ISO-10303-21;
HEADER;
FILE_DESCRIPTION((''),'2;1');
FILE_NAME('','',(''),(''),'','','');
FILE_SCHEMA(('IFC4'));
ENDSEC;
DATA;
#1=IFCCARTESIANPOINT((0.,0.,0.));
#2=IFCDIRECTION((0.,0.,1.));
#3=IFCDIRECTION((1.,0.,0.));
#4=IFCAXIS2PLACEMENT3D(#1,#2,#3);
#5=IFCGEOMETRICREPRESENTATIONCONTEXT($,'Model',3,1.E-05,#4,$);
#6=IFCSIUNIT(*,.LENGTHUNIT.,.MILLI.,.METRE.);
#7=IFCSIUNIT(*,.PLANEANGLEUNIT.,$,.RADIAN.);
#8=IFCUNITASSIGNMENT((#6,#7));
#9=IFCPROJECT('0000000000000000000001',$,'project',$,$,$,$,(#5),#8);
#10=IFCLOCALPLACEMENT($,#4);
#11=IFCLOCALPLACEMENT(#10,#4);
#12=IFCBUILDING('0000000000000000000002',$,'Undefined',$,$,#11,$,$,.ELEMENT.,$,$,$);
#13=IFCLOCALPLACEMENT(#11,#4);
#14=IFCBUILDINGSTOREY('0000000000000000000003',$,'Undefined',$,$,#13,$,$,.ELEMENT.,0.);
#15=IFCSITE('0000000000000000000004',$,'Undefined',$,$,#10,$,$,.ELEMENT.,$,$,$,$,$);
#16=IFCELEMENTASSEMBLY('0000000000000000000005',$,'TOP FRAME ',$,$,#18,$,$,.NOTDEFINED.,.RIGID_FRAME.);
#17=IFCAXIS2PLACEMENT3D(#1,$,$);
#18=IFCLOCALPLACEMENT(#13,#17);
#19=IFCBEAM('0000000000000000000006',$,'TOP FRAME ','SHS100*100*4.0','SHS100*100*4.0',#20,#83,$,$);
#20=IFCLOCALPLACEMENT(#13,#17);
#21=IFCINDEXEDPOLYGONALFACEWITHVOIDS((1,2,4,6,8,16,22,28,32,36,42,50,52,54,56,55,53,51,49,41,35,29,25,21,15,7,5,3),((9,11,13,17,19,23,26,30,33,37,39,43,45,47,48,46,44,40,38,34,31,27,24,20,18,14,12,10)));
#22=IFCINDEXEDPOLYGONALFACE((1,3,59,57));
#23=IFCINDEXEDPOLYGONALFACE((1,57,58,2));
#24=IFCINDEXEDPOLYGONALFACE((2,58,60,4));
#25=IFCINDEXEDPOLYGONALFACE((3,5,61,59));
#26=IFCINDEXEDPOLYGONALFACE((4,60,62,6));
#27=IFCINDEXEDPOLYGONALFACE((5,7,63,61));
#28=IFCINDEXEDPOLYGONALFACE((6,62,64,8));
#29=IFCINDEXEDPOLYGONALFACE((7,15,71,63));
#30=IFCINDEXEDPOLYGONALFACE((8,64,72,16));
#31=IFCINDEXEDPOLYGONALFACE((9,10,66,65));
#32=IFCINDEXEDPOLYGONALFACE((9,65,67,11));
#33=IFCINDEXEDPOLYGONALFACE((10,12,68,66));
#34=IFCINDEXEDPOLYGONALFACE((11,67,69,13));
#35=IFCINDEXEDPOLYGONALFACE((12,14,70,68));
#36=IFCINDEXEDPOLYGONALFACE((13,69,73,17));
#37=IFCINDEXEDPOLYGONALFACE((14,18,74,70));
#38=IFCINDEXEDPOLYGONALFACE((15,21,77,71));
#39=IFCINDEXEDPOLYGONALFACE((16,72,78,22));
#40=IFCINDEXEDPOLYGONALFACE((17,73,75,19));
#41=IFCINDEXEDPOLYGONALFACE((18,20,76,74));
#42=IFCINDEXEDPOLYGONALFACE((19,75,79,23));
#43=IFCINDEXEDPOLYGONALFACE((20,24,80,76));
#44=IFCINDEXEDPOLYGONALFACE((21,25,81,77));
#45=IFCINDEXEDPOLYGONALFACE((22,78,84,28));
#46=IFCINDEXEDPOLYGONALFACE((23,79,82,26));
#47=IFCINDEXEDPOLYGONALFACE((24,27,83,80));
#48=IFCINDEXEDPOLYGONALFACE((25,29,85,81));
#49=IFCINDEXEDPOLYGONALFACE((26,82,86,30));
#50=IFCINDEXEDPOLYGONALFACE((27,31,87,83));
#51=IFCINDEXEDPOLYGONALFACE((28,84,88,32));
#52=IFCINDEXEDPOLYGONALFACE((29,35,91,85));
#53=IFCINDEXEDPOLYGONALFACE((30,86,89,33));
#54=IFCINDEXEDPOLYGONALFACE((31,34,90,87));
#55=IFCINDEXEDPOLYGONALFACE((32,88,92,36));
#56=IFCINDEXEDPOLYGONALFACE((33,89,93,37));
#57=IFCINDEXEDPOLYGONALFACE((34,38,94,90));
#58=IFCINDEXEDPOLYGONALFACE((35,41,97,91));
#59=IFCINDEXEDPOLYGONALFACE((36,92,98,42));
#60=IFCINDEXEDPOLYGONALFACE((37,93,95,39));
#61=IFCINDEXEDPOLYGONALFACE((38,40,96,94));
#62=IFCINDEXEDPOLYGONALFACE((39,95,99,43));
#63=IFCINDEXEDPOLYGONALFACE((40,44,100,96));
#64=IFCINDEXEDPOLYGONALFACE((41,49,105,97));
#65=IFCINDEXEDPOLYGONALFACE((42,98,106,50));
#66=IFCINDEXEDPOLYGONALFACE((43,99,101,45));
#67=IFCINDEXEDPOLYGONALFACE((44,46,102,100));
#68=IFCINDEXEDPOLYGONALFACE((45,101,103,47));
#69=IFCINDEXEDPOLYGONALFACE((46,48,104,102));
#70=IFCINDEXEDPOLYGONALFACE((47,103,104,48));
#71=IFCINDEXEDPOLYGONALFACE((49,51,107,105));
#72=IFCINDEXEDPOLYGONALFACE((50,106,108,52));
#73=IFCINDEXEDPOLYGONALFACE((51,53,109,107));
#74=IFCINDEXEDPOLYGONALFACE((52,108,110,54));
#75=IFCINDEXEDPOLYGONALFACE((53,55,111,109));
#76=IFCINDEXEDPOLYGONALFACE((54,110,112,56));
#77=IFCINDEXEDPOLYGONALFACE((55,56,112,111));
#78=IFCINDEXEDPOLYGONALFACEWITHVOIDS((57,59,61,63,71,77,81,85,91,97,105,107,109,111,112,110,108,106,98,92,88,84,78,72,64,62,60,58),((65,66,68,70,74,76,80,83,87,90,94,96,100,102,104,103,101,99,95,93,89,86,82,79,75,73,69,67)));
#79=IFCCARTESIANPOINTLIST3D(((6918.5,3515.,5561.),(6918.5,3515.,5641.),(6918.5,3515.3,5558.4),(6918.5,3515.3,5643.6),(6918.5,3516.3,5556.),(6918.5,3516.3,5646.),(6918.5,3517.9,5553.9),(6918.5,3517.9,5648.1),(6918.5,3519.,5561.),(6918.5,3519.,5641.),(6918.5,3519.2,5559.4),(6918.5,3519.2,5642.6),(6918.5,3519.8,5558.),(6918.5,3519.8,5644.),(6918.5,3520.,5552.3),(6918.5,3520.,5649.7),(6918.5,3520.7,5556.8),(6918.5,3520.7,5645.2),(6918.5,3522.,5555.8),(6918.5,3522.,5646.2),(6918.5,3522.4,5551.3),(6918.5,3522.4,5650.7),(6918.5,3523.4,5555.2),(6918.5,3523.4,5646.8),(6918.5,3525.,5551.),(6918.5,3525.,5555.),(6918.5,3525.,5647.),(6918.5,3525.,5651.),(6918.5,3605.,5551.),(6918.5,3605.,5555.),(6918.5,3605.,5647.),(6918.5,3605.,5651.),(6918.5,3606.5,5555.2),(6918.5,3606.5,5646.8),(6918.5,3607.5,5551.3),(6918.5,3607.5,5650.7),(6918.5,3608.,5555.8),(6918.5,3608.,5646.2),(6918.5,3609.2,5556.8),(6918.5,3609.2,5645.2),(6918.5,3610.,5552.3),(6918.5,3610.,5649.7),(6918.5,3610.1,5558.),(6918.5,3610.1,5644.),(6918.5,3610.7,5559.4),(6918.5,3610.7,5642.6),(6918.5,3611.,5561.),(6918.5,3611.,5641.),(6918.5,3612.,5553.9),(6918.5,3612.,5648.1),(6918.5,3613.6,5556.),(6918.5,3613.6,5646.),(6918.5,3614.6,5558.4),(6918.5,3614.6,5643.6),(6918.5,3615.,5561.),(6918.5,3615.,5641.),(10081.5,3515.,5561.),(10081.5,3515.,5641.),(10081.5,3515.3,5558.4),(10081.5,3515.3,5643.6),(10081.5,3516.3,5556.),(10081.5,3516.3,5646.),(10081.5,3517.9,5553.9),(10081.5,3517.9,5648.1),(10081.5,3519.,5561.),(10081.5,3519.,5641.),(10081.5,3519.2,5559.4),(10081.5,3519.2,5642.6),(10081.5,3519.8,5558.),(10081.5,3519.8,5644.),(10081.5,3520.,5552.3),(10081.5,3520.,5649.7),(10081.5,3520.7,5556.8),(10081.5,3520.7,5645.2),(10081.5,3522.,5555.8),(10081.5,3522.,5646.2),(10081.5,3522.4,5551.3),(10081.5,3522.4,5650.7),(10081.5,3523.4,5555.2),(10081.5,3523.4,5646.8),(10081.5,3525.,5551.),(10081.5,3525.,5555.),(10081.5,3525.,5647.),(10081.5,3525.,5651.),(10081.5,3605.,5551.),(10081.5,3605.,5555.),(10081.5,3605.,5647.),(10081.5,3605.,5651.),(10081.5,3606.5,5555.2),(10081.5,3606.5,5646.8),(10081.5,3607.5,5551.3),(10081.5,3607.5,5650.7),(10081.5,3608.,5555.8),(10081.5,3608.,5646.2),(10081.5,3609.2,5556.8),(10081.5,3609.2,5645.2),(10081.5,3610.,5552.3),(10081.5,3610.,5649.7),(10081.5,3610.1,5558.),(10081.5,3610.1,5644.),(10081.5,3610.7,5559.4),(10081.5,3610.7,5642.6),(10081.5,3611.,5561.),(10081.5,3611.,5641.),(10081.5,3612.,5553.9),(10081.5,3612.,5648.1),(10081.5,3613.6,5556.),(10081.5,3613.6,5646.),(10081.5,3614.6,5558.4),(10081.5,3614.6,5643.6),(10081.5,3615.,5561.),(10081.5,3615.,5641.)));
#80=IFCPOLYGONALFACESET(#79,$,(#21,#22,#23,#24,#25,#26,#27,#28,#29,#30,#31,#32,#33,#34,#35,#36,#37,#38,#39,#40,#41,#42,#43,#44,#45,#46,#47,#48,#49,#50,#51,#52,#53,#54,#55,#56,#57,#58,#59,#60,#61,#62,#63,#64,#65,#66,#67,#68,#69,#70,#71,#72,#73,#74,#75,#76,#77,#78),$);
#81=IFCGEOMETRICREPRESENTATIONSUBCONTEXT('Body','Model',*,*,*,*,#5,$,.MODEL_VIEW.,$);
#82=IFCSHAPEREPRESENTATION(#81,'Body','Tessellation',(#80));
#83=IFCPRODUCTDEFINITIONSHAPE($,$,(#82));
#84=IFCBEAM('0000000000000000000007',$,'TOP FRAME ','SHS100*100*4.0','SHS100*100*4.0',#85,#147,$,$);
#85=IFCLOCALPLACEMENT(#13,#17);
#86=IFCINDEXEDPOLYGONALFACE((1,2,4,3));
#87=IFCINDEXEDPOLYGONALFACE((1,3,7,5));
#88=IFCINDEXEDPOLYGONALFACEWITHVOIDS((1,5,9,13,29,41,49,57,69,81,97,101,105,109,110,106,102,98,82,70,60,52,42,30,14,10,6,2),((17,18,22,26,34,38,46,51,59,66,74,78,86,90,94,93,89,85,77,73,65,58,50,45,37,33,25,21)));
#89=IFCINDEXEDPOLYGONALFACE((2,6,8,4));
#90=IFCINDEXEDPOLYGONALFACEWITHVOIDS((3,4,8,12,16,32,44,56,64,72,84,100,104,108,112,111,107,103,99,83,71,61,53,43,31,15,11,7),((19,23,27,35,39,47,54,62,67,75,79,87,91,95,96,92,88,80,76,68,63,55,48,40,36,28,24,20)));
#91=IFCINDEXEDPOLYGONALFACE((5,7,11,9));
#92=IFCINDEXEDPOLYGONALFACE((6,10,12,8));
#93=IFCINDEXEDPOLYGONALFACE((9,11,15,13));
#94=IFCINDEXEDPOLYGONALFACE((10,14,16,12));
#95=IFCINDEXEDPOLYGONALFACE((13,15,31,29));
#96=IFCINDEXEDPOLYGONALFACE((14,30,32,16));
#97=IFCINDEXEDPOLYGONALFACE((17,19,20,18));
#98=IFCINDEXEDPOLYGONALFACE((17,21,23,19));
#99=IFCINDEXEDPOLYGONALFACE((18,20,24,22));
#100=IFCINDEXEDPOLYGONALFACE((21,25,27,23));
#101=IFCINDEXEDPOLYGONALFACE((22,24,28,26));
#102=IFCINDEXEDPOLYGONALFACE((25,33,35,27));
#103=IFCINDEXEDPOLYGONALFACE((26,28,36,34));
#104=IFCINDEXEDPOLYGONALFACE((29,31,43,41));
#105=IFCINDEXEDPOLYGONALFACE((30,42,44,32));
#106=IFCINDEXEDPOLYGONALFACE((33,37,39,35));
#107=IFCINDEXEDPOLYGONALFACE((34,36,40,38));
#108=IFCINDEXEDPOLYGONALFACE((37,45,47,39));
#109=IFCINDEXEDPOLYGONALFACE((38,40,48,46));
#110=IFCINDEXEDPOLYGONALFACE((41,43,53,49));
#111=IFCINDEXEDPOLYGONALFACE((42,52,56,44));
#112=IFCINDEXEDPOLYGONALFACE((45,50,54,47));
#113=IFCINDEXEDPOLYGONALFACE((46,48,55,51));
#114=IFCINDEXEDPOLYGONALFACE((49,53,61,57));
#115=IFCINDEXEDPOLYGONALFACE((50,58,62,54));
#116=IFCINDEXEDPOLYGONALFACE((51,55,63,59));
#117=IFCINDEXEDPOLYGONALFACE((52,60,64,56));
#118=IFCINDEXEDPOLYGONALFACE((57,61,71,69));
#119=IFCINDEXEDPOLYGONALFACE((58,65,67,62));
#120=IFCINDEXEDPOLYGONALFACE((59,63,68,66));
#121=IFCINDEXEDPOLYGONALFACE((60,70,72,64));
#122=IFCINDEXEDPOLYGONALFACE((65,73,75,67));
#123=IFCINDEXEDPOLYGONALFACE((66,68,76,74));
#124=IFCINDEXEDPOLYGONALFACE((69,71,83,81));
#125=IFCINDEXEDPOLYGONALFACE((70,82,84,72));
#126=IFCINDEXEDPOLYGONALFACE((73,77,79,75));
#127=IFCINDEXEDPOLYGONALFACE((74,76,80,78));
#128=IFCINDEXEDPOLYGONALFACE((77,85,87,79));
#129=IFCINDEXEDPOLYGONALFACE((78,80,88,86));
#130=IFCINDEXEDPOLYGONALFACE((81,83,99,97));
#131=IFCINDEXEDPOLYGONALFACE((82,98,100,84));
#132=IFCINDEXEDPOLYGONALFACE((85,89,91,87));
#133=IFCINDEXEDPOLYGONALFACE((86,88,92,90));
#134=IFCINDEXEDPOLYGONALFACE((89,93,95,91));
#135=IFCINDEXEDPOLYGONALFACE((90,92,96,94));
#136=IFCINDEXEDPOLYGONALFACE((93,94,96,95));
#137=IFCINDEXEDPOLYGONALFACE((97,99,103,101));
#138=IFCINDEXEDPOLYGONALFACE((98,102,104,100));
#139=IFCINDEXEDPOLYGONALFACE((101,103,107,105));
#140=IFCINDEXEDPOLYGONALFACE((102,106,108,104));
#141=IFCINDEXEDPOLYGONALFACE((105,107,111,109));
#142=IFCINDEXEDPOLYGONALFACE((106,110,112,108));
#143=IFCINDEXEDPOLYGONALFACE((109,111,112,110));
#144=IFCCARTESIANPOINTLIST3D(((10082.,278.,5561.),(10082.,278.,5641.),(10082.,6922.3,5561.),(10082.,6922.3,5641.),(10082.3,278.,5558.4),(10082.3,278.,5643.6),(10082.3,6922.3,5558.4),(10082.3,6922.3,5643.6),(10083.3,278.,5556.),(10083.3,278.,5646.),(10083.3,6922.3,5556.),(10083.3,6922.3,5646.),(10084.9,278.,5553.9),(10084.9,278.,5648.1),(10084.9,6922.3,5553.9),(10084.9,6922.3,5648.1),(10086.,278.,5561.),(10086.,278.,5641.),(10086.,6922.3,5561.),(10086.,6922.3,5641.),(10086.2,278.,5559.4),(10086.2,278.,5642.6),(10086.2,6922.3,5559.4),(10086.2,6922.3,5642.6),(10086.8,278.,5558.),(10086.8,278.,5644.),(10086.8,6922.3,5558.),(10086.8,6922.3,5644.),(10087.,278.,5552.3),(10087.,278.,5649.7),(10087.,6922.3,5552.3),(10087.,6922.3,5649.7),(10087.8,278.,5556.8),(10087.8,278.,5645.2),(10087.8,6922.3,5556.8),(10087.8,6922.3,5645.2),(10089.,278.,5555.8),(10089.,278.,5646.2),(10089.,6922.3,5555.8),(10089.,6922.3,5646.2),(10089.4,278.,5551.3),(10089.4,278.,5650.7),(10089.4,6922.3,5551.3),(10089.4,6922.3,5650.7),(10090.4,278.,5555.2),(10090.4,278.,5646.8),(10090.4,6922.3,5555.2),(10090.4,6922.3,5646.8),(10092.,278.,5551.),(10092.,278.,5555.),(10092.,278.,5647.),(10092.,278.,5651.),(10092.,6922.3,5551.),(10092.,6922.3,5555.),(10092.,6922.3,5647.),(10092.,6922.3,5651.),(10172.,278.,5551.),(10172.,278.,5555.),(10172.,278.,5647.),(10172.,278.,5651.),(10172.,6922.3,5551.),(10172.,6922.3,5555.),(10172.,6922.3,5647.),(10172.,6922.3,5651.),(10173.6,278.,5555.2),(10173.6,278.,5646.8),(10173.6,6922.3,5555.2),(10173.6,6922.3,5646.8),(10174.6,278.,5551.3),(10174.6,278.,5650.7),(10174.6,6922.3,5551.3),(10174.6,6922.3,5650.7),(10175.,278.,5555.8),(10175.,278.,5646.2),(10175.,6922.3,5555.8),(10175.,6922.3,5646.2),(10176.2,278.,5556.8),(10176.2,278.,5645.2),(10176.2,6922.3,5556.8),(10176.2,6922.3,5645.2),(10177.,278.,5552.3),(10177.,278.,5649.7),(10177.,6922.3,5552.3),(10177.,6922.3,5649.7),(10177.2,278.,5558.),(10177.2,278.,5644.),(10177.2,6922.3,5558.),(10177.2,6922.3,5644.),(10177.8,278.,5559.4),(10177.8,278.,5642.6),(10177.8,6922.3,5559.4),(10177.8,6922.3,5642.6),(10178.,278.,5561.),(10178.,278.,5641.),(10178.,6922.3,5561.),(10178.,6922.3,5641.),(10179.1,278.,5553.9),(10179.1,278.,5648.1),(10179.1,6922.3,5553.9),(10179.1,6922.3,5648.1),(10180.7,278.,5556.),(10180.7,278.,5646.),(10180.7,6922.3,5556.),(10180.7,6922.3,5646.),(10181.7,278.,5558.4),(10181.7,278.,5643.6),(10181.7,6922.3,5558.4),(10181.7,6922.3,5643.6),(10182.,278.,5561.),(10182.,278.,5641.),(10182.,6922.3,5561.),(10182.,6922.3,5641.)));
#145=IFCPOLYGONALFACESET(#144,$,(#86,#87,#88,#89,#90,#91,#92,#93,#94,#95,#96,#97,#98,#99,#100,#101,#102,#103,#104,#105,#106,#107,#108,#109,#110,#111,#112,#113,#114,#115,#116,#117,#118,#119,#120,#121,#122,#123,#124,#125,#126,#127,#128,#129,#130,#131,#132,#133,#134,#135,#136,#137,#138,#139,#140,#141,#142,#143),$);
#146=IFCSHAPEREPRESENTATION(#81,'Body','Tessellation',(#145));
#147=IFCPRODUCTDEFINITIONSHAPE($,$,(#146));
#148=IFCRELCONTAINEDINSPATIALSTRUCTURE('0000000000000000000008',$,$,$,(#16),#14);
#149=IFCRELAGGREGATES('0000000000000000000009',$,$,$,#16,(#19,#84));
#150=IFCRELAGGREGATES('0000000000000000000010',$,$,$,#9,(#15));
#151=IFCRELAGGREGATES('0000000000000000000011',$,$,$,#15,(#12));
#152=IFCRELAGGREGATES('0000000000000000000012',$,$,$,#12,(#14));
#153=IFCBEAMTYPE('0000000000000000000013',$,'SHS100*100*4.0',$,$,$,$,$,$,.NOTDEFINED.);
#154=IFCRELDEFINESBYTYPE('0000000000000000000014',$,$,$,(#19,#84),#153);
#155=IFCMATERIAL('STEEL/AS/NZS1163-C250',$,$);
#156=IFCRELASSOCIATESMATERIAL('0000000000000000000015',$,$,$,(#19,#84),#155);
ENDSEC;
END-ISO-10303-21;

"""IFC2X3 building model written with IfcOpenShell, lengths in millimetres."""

from ifc_helpers import new_model, si_unit, frame, origin_with_axes, origin_2d_with_axis, place, context, subcontext, project, spatial, hollow_rectangle, extrude, material, type_object, element, aggregate, save


model = new_model("IFC2X3")

# Units and contexts
model_context = context("Model", 3, precision=1e-05, world=origin_with_axes())
body_context = subcontext(model_context, "Body", "Model", "MODEL_VIEW")
ifc_project = project(units=[si_unit("LENGTHUNIT", "METRE", prefix="MILLI"), si_unit("PLANEANGLEUNIT", "RADIAN")], contexts=[model_context])

# Site, building, storey
site_placement = place(None, origin_with_axes())
site = spatial("IfcSite", under=ifc_project, at=site_placement, Name="Undefined", CompositionType="ELEMENT")
building_placement = place(site_placement, origin_with_axes())
building = spatial("IfcBuilding", under=site, at=building_placement, Name="Undefined", CompositionType="ELEMENT")
storey_placement = place(building_placement, origin_with_axes())
storey = spatial("IfcBuildingStorey", under=building, at=storey_placement, Name="Undefined", CompositionType="ELEMENT", Elevation=0.0)

# Element assembly, beams
ifc_material_1 = material(Name="STEEL/AS/NZS1163-C250")
beam_type_1 = type_object("IfcBeamType", Name="SHS100*100*4.0", PredefinedType="NOTDEFINED")
assembly_1_placement = place(storey_placement, origin_with_axes())
assembly_1 = element("IfcElementAssembly", 1, at=assembly_1_placement, inside=storey, Name="TOP FRAME ", AssemblyPlace="NOTDEFINED", PredefinedType="RIGID_FRAME")
beam_1_placement = place(assembly_1_placement, frame((10081.5, 3564.9, 5601.0), z_axis=(0.0, 0.0, 1.0), x_axis=(-1.0, 0.0, 0.0)))
beam_1 = element("IfcBeam", 2, at=beam_1_placement, type_object=beam_type_1, material=ifc_material_1, Name="TOP FRAME ", Description="SHS100*100*4.0", ObjectType="SHS100*100*4.0", context=body_context, shape_type="SweptSolid", body=[
    extrude(hollow_rectangle(XDim=100.0, YDim=100.0, WallThickness=4.0, InnerFilletRadius=6.0, OuterFilletRadius=10.0, at=origin_2d_with_axis()), frame((3163.0, 0.0, 0.0), z_axis=(-1.0, 0.0, 0.0), x_axis=(0.0, -1.0, 0.0)), (0.0, 0.0, 1.0), 3163.0),
])
beam_2_placement = place(assembly_1_placement, frame((10132.0, 6922.3, 5601.0), z_axis=(0.0, 0.0, 1.0), x_axis=(0.0, -1.0, 0.0)))
beam_2 = element("IfcBeam", 3, at=beam_2_placement, type_object=beam_type_1, material=ifc_material_1, Name="TOP FRAME ", Description="SHS100*100*4.0", ObjectType="SHS100*100*4.0", context=body_context, shape_type="SweptSolid", body=[
    extrude(hollow_rectangle(XDim=100.0, YDim=100.0, WallThickness=4.0, InnerFilletRadius=6.0, OuterFilletRadius=10.0, at=origin_2d_with_axis()), frame((6644.3, 0.0, 0.0), z_axis=(-1.0, 0.0, 0.0), x_axis=(0.0, -1.0, 0.0)), (0.0, 0.0, 1.0), 6644.3),
])
aggregate(assembly_1, [beam_1, beam_2])

save(model, "model.ifc")
